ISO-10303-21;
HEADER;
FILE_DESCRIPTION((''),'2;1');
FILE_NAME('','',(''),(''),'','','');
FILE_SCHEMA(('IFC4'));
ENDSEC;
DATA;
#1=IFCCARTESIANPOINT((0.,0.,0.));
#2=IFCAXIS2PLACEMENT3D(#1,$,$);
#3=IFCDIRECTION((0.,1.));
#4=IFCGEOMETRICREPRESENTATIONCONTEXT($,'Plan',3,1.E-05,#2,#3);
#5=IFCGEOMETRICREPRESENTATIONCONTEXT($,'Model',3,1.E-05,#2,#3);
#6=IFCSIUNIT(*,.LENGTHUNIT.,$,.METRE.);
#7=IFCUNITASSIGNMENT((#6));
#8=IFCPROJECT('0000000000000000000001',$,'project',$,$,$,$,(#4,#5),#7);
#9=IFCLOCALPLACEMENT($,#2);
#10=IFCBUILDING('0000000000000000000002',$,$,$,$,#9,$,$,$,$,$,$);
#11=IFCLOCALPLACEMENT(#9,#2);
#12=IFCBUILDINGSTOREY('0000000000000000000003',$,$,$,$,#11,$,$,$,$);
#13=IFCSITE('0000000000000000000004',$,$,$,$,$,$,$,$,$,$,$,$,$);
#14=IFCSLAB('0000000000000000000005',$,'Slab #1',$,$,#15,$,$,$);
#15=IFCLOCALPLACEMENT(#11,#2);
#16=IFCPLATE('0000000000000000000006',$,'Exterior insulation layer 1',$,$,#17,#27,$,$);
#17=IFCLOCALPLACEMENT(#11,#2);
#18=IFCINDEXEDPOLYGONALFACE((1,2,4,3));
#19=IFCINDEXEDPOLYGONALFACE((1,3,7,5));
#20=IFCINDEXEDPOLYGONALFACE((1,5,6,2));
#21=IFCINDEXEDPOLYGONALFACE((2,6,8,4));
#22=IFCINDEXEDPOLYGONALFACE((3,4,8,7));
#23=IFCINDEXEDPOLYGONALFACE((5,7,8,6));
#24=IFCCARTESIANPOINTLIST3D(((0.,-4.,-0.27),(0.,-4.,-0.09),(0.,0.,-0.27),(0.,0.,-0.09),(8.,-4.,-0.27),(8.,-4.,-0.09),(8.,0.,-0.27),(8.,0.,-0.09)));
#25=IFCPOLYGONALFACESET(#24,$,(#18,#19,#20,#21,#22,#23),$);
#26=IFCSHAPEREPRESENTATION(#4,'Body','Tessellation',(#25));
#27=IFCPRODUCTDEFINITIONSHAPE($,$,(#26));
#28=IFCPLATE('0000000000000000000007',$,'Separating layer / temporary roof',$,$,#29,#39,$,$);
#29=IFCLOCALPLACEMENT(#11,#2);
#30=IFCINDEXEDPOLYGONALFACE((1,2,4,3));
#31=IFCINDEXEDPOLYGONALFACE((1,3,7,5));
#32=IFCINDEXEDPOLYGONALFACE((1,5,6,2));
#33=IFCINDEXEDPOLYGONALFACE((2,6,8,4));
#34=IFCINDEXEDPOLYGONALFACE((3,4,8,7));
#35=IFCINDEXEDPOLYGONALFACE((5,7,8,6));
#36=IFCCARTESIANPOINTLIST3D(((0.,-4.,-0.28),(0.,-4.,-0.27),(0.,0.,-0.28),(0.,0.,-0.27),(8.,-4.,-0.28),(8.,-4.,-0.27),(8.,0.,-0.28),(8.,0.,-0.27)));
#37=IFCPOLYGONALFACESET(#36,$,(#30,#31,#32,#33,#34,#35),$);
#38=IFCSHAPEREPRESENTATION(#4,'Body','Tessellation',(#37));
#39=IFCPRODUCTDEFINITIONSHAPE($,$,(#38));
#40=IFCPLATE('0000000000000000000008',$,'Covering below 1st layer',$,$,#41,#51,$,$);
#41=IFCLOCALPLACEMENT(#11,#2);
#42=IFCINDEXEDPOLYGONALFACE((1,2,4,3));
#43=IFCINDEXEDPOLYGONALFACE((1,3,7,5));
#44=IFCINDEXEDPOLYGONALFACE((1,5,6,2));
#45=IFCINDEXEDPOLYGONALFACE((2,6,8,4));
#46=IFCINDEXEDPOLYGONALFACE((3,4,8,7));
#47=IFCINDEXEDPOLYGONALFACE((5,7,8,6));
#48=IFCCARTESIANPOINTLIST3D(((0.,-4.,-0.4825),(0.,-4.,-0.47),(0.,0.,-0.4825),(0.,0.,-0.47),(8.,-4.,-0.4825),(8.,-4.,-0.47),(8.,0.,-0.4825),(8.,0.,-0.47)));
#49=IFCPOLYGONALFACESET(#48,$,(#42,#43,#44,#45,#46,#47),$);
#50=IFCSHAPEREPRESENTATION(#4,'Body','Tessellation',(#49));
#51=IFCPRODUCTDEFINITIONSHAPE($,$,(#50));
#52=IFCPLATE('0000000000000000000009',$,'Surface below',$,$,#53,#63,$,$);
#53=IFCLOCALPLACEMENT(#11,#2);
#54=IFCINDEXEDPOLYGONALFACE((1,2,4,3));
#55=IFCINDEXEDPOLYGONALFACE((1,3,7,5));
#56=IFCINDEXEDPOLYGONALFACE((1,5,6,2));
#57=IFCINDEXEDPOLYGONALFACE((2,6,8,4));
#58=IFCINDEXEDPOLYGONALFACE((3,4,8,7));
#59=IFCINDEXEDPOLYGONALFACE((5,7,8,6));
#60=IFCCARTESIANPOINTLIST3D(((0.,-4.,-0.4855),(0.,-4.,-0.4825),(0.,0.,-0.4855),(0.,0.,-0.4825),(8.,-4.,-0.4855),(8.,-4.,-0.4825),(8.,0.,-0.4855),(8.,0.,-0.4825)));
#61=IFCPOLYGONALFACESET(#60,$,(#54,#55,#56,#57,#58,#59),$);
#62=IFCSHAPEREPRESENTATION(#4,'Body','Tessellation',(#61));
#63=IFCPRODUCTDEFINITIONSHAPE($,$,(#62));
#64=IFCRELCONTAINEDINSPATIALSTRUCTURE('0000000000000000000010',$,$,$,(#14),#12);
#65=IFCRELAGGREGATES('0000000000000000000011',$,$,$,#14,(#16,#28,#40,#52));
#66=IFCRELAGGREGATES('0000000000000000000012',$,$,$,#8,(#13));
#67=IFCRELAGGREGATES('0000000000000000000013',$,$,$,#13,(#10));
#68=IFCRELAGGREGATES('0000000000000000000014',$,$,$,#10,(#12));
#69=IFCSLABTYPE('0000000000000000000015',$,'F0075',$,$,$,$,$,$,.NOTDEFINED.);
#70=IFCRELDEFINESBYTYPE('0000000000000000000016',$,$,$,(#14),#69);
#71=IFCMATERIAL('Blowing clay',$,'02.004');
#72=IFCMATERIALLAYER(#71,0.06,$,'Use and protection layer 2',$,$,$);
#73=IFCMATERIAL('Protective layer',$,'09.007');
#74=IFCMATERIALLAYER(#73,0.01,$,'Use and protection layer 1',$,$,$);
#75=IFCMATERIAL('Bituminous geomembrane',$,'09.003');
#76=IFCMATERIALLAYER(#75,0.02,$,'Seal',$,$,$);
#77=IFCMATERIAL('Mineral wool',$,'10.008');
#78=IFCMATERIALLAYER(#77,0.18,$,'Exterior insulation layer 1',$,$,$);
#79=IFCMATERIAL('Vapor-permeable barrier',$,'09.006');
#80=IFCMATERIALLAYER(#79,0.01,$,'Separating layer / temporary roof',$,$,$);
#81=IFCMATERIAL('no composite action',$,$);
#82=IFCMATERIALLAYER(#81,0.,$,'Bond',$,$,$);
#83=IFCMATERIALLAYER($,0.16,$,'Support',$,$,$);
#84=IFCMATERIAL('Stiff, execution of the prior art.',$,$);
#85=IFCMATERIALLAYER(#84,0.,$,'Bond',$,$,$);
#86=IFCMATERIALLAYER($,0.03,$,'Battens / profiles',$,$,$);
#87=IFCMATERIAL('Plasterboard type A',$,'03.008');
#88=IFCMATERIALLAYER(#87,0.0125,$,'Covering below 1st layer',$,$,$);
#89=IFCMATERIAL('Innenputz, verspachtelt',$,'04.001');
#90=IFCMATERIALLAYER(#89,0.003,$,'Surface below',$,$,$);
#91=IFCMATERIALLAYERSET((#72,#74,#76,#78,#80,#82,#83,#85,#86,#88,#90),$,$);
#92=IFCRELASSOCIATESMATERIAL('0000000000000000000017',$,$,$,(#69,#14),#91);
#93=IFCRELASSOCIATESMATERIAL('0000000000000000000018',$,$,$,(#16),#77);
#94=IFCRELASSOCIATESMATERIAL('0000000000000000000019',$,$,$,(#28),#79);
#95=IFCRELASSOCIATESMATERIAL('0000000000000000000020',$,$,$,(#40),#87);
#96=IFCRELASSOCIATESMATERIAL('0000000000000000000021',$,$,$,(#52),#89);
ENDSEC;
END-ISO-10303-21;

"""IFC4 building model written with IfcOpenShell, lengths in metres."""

from ifc_helpers import new_model, si_unit, direction, frame, frame_2d, origin, place, context, project, spatial, rectangle, extrude, material, layer, layer_set, type_object, element, aggregate, save


model = new_model("IFC4")

# Units and contexts
plan_context = context("Plan", 3, precision=1e-05, world=origin(), true_north=direction((0.0, 1.0)))
model_context = context("Model", 3, precision=1e-05, world=origin(), true_north=direction((0.0, 1.0)))
ifc_project = project(units=[si_unit("LENGTHUNIT", "METRE")], contexts=[plan_context, model_context])

# Site, building, storey
site = spatial("IfcSite", under=ifc_project)
building_placement = place(None, origin())
building = spatial("IfcBuilding", under=site, at=building_placement)
storey_placement = place(building_placement, origin())
storey = spatial("IfcBuildingStorey", under=building, at=storey_placement)

# Slab, plates
ifc_material_1 = material(Name="Blowing clay", Category="02.004")
ifc_layer_1 = layer(ifc_material_1, 0.06, Name="Use and protection layer 2")
ifc_material_2 = material(Name="Protective layer", Category="09.007")
ifc_layer_2 = layer(ifc_material_2, 0.01, Name="Use and protection layer 1")
ifc_material_3 = material(Name="Bituminous geomembrane", Category="09.003")
ifc_layer_3 = layer(ifc_material_3, 0.02, Name="Seal")
ifc_material_4 = material(Name="Mineral wool", Category="10.008")
ifc_layer_4 = layer(ifc_material_4, 0.18, Name="Exterior insulation layer 1")
ifc_material_5 = material(Name="Vapor-permeable barrier", Category="09.006")
ifc_layer_5 = layer(ifc_material_5, 0.01, Name="Separating layer / temporary roof")
ifc_material_6 = material(Name="no composite action")
ifc_layer_6 = layer(ifc_material_6, 0.0, Name="Bond")
ifc_layer_7 = layer(None, 0.16, Name="Support")
ifc_material_7 = material(Name="Stiff, execution of the prior art.")
ifc_layer_8 = layer(ifc_material_7, 0.0, Name="Bond")
ifc_layer_9 = layer(None, 0.03, Name="Battens / profiles")
ifc_material_8 = material(Name="Plasterboard type A", Category="03.008")
ifc_layer_10 = layer(ifc_material_8, 0.0125, Name="Covering below 1st layer")
ifc_material_9 = material(Name="Innenputz, verspachtelt", Category="04.001")
ifc_layer_11 = layer(ifc_material_9, 0.003, Name="Surface below")
ifc_layer_set = layer_set([ifc_layer_1, ifc_layer_2, ifc_layer_3, ifc_layer_4, ifc_layer_5, ifc_layer_6, ifc_layer_7, ifc_layer_8, ifc_layer_9, ifc_layer_10, ifc_layer_11])
slab_type = type_object("IfcSlabType", Name="F0075", PredefinedType="NOTDEFINED", material=ifc_layer_set)
slab_placement = place(None, frame((0.0, 0.0, 0.0), z_axis=(0.0, 0.0, -1.0), x_axis=(1.0, 0.0, 0.0)))
slab = element("IfcSlab", 1, at=slab_placement, inside=storey, type_object=slab_type, material=ifc_layer_set, Name="Slab #1")
plate_1_placement = place(slab_placement, origin())
plate_1 = element("IfcPlate", 2, at=plate_1_placement, material=ifc_material_4, Name="Exterior insulation layer 1", context=plan_context, shape_type="SweptSolid", body=[
    extrude(rectangle(XDim=8.0, YDim=4.0, at=frame_2d((4.0, 2.0), x_axis=(1.0, 0.0))), frame((0.0, 0.0, 0.09), z_axis=(0.0, 0.0, 1.0), x_axis=(1.0, 0.0, 0.0)), (0.0, 0.0, 1.0), 0.18),
])
plate_2_placement = place(slab_placement, origin())
plate_2 = element("IfcPlate", 3, at=plate_2_placement, material=ifc_material_5, Name="Separating layer / temporary roof", context=plan_context, shape_type="SweptSolid", body=[
    extrude(rectangle(XDim=8.0, YDim=4.0, at=frame_2d((4.0, 2.0), x_axis=(1.0, 0.0))), frame((0.0, 0.0, 0.27), z_axis=(0.0, 0.0, 1.0), x_axis=(1.0, 0.0, 0.0)), (0.0, 0.0, 1.0), 0.01),
])
plate_3_placement = place(slab_placement, origin())
plate_3 = element("IfcPlate", 4, at=plate_3_placement, material=ifc_material_8, Name="Covering below 1st layer", context=plan_context, shape_type="SweptSolid", body=[
    extrude(rectangle(XDim=8.0, YDim=4.0, at=frame_2d((4.0, 2.0), x_axis=(1.0, 0.0))), frame((0.0, 0.0, 0.47), z_axis=(0.0, 0.0, 1.0), x_axis=(1.0, 0.0, 0.0)), (0.0, 0.0, 1.0), 0.0125),
])
plate_4_placement = place(slab_placement, origin())
plate_4 = element("IfcPlate", 5, at=plate_4_placement, material=ifc_material_9, Name="Surface below", context=plan_context, shape_type="SweptSolid", body=[
    extrude(rectangle(XDim=8.0, YDim=4.0, at=frame_2d((4.0, 2.0), x_axis=(1.0, 0.0))), frame((0.0, 0.0, 0.4825), z_axis=(0.0, 0.0, 1.0), x_axis=(1.0, 0.0, 0.0)), (0.0, 0.0, 1.0), 0.003),
])
aggregate(slab, [plate_1, plate_2, plate_3, plate_4])

save(model, "model.ifc")
